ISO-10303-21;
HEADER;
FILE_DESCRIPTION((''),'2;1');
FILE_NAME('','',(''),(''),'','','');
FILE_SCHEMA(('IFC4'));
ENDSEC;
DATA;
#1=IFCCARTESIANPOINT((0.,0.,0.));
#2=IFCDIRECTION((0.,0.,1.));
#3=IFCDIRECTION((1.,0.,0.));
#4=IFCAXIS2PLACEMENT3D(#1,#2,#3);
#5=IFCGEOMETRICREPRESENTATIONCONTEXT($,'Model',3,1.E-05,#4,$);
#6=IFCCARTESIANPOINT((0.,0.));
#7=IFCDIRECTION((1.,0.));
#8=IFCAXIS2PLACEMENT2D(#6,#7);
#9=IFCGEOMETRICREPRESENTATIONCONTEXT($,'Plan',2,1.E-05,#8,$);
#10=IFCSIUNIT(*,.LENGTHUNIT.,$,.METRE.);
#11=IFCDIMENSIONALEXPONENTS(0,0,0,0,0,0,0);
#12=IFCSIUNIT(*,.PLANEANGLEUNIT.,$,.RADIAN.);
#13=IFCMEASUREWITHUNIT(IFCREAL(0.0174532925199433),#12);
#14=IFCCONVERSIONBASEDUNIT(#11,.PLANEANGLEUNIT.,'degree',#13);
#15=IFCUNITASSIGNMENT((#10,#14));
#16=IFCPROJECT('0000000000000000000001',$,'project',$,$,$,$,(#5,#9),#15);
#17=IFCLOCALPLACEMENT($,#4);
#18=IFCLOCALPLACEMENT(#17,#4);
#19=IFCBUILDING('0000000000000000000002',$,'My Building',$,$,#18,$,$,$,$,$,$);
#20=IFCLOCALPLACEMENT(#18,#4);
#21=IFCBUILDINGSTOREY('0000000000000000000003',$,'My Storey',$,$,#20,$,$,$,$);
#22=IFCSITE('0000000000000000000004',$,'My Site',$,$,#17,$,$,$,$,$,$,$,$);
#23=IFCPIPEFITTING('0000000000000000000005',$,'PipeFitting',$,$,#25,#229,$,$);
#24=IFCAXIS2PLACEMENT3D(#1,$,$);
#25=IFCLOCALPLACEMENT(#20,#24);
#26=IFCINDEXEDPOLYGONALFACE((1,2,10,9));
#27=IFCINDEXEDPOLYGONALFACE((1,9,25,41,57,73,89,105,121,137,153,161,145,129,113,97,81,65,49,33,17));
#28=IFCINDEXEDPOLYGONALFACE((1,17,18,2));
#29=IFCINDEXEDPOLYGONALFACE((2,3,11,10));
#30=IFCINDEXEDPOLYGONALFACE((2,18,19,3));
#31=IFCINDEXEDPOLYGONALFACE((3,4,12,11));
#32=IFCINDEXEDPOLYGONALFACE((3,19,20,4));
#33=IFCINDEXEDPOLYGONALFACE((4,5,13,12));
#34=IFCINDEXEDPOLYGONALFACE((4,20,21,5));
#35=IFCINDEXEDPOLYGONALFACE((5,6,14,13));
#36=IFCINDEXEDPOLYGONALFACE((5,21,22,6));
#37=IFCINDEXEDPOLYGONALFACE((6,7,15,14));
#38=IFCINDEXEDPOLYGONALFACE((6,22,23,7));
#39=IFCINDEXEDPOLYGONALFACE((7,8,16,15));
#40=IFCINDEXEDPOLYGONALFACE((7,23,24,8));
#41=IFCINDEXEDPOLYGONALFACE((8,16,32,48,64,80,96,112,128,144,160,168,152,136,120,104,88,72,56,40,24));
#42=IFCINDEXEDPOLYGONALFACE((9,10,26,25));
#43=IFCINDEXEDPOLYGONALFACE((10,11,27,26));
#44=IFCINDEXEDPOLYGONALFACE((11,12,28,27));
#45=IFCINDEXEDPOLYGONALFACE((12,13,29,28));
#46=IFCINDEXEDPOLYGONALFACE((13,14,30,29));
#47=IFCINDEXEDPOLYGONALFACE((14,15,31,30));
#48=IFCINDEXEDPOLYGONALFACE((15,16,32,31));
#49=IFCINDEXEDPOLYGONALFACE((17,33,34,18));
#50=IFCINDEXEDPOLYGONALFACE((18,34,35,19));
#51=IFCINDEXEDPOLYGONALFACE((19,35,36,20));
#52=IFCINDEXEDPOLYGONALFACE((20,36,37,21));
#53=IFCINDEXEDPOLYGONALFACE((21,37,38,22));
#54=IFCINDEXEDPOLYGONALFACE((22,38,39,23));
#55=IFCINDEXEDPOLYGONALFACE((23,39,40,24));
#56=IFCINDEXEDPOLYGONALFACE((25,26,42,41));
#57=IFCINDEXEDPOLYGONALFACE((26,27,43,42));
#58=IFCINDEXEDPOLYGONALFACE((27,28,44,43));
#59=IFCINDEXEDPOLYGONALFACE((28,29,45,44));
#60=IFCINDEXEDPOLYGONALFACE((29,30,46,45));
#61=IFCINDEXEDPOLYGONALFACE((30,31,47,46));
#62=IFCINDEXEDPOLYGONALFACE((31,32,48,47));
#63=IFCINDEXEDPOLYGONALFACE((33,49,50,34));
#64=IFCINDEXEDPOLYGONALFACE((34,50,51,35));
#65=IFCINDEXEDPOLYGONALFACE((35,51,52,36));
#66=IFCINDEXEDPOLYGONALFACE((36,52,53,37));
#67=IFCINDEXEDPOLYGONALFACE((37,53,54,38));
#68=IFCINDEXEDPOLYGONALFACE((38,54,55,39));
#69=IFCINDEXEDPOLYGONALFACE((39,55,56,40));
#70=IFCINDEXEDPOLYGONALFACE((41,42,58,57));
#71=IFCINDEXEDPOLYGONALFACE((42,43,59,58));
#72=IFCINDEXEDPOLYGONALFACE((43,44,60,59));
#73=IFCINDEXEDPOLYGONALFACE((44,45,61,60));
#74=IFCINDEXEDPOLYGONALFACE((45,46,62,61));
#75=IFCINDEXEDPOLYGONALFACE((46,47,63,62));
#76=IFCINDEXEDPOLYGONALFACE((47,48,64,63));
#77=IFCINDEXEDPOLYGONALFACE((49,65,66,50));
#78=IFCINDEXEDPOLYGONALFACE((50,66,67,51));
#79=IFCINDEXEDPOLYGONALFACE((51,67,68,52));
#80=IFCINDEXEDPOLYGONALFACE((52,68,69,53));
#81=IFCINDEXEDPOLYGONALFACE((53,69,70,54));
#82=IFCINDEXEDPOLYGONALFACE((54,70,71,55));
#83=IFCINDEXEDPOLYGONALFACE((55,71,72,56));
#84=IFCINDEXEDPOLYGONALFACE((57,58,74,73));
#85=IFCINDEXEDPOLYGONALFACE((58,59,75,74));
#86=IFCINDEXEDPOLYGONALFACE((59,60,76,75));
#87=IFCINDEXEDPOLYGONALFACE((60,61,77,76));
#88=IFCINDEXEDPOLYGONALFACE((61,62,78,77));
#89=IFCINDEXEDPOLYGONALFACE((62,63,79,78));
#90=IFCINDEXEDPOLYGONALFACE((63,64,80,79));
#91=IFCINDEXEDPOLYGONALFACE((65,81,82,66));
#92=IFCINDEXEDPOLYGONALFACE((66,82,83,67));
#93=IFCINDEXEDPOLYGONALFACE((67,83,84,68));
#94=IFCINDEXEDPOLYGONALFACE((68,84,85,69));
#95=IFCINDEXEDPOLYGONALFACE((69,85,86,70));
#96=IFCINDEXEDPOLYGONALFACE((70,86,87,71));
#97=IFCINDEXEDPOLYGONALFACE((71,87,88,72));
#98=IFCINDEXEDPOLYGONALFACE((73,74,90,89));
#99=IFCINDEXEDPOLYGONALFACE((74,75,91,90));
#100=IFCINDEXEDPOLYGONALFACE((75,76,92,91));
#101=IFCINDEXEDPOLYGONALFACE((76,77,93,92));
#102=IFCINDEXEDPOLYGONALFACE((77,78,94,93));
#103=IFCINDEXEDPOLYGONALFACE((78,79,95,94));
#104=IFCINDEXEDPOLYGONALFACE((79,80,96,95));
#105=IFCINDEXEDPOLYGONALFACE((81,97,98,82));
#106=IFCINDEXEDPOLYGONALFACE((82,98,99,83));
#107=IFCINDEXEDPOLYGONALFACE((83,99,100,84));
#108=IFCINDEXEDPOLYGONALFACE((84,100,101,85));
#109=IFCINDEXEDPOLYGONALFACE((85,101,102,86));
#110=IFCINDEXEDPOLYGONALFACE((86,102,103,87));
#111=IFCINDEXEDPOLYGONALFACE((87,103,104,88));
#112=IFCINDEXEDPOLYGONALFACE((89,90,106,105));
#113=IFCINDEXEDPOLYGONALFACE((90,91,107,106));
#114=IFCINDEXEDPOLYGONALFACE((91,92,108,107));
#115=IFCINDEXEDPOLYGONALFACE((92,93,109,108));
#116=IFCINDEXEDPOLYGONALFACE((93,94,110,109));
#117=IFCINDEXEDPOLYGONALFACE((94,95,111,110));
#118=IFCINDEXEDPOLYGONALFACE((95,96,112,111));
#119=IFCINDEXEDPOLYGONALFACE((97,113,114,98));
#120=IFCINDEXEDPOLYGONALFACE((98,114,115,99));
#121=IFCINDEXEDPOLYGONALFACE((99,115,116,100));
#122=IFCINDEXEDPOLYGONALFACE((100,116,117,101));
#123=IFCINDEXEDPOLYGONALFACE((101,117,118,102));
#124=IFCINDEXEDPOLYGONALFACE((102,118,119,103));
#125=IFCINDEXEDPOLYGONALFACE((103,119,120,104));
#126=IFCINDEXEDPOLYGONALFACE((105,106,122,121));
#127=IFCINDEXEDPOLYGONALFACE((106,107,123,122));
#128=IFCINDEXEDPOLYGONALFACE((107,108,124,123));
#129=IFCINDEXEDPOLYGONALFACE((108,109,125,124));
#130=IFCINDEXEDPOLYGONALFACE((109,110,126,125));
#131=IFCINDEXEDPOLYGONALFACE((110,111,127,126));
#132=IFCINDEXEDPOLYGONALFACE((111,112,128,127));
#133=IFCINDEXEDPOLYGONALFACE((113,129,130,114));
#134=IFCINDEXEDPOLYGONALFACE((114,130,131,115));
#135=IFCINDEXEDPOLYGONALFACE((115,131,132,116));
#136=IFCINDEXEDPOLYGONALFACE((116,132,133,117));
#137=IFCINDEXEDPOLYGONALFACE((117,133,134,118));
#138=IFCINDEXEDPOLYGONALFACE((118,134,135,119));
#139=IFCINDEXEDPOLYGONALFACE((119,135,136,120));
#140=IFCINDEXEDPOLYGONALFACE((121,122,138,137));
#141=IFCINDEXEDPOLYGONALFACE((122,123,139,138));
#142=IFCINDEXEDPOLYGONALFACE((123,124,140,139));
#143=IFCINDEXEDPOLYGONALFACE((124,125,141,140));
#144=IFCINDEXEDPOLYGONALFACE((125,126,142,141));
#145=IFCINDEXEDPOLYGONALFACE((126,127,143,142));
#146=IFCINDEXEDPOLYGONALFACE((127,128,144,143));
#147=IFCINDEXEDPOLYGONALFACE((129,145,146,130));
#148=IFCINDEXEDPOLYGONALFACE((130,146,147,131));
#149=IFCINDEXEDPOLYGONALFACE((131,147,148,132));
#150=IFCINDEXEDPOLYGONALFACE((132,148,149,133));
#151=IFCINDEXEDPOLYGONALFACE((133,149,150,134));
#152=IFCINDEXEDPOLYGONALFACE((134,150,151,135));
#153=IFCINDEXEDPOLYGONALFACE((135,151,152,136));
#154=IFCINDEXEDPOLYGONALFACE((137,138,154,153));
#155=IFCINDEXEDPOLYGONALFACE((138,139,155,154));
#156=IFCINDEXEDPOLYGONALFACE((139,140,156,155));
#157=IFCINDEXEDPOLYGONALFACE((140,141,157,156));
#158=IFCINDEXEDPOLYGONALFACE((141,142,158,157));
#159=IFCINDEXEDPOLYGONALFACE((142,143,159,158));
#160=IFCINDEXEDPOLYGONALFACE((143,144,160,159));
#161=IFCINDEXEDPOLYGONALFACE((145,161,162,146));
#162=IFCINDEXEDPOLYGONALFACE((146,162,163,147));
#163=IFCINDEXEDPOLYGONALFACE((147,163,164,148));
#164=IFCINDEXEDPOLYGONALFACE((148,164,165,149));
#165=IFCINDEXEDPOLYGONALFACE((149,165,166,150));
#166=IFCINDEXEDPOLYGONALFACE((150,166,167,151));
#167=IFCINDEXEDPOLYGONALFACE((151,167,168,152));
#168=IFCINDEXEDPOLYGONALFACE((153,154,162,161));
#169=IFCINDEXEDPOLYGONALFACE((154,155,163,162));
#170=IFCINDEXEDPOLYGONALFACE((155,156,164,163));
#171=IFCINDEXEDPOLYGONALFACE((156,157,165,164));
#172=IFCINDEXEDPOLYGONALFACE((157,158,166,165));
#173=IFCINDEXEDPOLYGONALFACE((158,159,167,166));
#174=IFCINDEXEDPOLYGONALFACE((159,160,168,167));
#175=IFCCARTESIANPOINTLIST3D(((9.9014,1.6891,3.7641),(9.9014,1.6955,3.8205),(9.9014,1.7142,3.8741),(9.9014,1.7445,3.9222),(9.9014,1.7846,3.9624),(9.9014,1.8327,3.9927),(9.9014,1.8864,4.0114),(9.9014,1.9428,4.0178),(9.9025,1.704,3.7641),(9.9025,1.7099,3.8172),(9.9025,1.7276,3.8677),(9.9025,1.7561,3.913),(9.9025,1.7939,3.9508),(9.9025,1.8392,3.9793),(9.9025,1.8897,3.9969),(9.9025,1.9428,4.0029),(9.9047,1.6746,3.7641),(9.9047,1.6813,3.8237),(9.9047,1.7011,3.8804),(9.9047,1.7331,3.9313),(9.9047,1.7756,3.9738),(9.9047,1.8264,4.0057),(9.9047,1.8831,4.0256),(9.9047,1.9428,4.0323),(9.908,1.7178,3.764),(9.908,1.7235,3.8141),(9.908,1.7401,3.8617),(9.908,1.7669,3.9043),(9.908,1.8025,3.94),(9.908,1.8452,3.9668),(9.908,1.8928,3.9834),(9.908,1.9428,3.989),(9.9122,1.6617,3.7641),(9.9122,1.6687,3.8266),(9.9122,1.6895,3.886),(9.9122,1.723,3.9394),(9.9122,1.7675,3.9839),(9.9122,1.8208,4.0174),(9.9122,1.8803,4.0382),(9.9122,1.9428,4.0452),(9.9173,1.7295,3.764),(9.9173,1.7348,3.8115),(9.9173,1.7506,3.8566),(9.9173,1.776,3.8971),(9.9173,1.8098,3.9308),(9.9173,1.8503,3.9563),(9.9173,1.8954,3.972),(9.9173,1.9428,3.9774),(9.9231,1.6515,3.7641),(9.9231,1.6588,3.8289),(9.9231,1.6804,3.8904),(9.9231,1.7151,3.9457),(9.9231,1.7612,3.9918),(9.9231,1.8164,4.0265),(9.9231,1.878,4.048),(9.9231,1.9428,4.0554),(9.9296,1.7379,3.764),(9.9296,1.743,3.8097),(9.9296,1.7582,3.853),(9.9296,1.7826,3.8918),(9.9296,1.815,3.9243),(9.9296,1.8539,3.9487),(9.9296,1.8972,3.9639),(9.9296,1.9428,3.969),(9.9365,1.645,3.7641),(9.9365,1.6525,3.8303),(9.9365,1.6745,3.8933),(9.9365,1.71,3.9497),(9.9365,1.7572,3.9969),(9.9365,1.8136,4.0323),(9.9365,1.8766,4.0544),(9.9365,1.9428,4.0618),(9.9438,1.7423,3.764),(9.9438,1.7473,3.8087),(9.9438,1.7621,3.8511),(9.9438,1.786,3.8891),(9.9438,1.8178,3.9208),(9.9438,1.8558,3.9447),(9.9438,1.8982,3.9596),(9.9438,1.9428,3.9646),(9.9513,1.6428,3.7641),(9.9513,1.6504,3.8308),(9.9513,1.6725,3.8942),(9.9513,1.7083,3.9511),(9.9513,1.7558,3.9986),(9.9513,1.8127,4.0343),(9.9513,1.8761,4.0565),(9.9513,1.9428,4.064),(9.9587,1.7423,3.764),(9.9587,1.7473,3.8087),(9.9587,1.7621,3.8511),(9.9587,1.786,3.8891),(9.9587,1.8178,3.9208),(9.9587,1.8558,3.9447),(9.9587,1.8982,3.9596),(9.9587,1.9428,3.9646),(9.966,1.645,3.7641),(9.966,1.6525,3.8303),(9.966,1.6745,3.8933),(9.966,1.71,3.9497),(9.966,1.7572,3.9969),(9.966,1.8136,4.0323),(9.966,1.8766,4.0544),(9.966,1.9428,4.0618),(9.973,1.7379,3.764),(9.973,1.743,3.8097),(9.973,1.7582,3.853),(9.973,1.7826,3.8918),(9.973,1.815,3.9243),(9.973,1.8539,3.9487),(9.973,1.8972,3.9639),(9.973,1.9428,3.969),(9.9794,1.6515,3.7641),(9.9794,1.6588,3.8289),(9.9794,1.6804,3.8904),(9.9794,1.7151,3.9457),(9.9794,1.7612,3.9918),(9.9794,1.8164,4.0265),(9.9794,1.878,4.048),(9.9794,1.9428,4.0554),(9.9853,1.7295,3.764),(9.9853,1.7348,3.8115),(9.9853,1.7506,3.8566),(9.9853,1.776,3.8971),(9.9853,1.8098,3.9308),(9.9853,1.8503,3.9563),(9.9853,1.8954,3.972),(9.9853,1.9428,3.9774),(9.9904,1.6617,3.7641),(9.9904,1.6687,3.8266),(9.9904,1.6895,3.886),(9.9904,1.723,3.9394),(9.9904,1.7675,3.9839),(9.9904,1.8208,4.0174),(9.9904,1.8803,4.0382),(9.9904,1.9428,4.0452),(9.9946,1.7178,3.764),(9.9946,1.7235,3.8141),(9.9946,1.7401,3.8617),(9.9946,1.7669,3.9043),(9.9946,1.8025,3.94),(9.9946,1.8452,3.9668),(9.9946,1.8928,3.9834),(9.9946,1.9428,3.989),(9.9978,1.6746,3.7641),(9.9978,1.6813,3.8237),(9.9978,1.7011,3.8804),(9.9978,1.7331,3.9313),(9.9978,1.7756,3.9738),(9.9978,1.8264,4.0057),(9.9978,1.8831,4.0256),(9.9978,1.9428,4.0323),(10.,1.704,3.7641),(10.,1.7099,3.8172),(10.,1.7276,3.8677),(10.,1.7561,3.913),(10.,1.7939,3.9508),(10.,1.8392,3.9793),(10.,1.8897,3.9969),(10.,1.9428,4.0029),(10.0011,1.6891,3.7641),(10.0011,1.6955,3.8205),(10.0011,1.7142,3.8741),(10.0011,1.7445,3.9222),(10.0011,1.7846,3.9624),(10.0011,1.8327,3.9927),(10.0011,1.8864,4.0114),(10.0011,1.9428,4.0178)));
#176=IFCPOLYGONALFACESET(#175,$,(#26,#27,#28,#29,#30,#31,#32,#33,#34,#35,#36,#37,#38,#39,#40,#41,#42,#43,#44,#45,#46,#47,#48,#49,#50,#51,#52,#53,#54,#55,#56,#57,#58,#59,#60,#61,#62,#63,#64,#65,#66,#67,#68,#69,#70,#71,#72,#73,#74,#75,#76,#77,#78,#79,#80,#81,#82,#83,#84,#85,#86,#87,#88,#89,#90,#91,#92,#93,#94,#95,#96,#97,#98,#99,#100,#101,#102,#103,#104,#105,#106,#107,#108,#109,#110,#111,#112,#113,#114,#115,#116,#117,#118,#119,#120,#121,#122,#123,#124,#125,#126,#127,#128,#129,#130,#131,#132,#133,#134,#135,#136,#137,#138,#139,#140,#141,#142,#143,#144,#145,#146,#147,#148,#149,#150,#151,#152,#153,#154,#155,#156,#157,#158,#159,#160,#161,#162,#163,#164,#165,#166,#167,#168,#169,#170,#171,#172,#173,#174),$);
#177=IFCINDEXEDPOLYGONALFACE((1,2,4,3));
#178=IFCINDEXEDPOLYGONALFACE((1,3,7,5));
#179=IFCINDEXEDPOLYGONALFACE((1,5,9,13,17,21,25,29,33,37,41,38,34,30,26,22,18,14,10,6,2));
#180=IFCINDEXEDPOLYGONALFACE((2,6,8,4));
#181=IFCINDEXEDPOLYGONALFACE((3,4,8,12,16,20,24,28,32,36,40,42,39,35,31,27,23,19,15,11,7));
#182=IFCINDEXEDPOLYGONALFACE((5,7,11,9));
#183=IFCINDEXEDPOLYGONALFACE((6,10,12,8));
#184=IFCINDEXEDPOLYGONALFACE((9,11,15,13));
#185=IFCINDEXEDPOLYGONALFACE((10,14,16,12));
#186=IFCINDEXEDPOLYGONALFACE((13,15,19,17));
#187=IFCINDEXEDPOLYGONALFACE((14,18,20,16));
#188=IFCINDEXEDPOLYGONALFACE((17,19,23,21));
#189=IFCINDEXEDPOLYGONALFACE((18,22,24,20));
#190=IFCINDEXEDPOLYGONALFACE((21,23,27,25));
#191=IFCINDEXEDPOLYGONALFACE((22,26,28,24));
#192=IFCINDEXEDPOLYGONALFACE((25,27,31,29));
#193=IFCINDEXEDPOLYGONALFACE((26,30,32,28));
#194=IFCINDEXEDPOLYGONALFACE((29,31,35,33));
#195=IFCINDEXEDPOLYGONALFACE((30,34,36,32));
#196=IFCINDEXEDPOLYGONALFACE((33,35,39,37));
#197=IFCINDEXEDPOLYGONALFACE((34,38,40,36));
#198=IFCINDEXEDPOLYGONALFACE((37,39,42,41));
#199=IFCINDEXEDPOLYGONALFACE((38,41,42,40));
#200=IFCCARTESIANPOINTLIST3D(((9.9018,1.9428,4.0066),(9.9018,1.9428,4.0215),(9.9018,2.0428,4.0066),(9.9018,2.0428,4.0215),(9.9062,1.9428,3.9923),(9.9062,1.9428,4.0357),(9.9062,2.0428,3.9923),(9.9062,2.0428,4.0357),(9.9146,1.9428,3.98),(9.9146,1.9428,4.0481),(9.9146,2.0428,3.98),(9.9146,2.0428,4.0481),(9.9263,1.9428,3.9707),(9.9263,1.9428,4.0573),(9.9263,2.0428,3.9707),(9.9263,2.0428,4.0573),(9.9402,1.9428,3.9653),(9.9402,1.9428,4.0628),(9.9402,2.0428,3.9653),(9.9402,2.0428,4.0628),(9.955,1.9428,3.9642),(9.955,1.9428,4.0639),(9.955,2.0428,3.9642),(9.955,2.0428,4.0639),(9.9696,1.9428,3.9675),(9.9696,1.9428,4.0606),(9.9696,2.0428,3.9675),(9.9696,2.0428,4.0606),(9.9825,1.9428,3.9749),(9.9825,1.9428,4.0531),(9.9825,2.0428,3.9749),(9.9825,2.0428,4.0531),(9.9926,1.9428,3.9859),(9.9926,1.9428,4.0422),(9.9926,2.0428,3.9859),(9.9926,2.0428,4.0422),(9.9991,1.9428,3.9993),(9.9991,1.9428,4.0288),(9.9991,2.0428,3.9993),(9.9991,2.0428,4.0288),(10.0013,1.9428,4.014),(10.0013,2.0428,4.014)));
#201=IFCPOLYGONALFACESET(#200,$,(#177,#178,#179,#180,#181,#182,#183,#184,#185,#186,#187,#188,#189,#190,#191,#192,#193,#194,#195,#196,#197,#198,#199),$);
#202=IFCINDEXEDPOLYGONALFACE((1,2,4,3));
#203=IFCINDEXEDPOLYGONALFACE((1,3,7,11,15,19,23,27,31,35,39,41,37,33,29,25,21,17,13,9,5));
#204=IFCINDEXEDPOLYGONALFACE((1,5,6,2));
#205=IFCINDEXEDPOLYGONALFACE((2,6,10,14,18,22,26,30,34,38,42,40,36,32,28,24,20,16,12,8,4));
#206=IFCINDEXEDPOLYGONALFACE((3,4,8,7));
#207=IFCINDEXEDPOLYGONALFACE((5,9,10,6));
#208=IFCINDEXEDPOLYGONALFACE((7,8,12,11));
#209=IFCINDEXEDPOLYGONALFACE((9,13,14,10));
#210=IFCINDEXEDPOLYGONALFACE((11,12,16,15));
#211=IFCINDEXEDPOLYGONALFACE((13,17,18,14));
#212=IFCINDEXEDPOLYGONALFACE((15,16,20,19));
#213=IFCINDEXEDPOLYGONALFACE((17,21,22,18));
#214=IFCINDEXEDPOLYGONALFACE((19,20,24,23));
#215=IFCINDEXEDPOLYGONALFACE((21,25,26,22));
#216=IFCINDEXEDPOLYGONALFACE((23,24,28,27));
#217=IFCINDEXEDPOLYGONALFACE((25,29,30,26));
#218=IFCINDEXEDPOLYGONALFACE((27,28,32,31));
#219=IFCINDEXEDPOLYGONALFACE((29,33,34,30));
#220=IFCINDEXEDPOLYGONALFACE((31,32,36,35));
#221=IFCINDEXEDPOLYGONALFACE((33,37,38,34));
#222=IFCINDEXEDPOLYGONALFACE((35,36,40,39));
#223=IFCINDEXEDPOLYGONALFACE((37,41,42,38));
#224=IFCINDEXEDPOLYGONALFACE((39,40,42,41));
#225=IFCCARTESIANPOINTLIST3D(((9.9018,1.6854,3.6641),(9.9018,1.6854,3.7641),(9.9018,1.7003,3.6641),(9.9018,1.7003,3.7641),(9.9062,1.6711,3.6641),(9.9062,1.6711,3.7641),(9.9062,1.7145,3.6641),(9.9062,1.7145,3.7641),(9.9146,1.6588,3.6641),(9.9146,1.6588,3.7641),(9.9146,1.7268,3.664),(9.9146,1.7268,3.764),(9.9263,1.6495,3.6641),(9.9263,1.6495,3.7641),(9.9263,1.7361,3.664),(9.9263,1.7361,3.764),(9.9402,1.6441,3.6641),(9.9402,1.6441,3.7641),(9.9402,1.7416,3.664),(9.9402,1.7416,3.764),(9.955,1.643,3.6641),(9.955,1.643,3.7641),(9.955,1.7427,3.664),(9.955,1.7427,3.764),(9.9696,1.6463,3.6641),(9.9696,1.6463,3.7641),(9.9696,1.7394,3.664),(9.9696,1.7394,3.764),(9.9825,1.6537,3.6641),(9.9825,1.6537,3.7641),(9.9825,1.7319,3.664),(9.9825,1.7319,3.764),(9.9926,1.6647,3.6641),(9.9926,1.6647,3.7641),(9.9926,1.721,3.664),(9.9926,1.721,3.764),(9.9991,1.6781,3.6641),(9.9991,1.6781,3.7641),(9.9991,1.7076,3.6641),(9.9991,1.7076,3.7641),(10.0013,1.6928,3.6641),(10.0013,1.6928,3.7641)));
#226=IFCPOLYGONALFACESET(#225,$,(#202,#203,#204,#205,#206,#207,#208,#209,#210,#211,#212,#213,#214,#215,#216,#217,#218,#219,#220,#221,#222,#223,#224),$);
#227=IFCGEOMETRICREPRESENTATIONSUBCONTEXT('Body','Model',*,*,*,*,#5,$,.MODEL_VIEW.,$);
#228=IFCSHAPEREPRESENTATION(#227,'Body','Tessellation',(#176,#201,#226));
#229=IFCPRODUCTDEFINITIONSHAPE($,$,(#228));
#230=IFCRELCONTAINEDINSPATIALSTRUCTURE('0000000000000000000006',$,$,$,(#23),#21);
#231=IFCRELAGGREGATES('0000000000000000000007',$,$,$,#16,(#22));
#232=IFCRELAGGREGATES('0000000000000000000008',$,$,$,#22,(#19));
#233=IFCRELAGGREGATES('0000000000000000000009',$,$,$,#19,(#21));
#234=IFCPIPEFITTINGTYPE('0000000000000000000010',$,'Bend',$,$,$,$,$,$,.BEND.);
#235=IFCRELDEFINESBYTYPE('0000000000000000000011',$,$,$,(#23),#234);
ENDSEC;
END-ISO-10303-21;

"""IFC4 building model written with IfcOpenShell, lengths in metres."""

from ifc_helpers import new_model, entity, si_unit, converted_unit, frame, origin_with_axes, origin_2d_with_axis, place, context, subcontext, project, spatial, circle, extrude, source, transform, mapped, type_object, type_shapes, element, save


model = new_model("IFC4")

# Units and contexts
model_context = context("Model", 3, precision=1e-05, world=origin_with_axes())
plan_context = context("Plan", 2, precision=1e-05, world=origin_2d_with_axis())
body_context_1 = subcontext(model_context, "Body", "Model", "MODEL_VIEW")
ifc_project = project(units=[si_unit("LENGTHUNIT", "METRE"), converted_unit("PLANEANGLEUNIT", "degree", entity("IfcReal", 0.0174532925199433), si_unit("PLANEANGLEUNIT", "RADIAN"), dimensions=[0, 0, 0, 0, 0, 0, 0])], contexts=[model_context, plan_context])

# Site, building, storey
site_placement = place(None, origin_with_axes())
site = spatial("IfcSite", under=ifc_project, at=site_placement, Name="My Site")
building_placement = place(site_placement, origin_with_axes())
building = spatial("IfcBuilding", under=site, at=building_placement, Name="My Building")
storey_placement = place(building_placement, origin_with_axes())
storey = spatial("IfcBuildingStorey", under=building, at=storey_placement, Name="My Storey")

# Pipe fitting
pipe_fitting_type_1 = type_object("IfcPipeFittingType", Name="Bend", PredefinedType="BEND")
shared_shape_1 = source(origin_with_axes(), body_context_1, "Body", "SolidModel", [
    entity("IfcSweptDiskSolid", entity("IfcIndexedPolyCurve", entity("IfcCartesianPointList3D", [[0.0, 0.0, 0.1], [0.0, -0.0732, 0.2768], [0.0, -0.25, 0.35]]), [entity("IfcArcIndex", [1, 2, 3])]), 0.05),
    extrude(circle(Radius=0.05), origin_with_axes(), (0.0, 0.0, 1.0), 0.1),
    extrude(circle(Radius=0.05), frame((0.0, -0.25, 0.35), z_axis=(0.0, -1.0, 0.000038), x_axis=(1.0, 0.0, 0.0)), (0.0, 0.0, 1.0), 0.1),
])
type_shapes(pipe_fitting_type_1, [shared_shape_1])
for number, where, z_axis, x_axis, name in (
    (1, (9.9513, 2.0428, 4.014), (0.0, -1.0, 0.0), (1.0, 0.0, 0.0), "PipeFitting"),
):
    element("IfcPipeFitting", number, at=place(storey_placement, frame(where, z_axis=z_axis, x_axis=x_axis)), inside=storey, type_object=pipe_fitting_type_1, Name=name, context=body_context_1, shape_type="MappedRepresentation", body=[
        mapped(shared_shape_1, transform((0.0, 0.0, 0.0), x_axis=(1.0, 0.0, 0.0), y_axis=(0.0, 1.0, 0.0), z_axis=(0.0, 0.0, 1.0), scale=1.0)),
    ])

save(model, "model.ifc")
